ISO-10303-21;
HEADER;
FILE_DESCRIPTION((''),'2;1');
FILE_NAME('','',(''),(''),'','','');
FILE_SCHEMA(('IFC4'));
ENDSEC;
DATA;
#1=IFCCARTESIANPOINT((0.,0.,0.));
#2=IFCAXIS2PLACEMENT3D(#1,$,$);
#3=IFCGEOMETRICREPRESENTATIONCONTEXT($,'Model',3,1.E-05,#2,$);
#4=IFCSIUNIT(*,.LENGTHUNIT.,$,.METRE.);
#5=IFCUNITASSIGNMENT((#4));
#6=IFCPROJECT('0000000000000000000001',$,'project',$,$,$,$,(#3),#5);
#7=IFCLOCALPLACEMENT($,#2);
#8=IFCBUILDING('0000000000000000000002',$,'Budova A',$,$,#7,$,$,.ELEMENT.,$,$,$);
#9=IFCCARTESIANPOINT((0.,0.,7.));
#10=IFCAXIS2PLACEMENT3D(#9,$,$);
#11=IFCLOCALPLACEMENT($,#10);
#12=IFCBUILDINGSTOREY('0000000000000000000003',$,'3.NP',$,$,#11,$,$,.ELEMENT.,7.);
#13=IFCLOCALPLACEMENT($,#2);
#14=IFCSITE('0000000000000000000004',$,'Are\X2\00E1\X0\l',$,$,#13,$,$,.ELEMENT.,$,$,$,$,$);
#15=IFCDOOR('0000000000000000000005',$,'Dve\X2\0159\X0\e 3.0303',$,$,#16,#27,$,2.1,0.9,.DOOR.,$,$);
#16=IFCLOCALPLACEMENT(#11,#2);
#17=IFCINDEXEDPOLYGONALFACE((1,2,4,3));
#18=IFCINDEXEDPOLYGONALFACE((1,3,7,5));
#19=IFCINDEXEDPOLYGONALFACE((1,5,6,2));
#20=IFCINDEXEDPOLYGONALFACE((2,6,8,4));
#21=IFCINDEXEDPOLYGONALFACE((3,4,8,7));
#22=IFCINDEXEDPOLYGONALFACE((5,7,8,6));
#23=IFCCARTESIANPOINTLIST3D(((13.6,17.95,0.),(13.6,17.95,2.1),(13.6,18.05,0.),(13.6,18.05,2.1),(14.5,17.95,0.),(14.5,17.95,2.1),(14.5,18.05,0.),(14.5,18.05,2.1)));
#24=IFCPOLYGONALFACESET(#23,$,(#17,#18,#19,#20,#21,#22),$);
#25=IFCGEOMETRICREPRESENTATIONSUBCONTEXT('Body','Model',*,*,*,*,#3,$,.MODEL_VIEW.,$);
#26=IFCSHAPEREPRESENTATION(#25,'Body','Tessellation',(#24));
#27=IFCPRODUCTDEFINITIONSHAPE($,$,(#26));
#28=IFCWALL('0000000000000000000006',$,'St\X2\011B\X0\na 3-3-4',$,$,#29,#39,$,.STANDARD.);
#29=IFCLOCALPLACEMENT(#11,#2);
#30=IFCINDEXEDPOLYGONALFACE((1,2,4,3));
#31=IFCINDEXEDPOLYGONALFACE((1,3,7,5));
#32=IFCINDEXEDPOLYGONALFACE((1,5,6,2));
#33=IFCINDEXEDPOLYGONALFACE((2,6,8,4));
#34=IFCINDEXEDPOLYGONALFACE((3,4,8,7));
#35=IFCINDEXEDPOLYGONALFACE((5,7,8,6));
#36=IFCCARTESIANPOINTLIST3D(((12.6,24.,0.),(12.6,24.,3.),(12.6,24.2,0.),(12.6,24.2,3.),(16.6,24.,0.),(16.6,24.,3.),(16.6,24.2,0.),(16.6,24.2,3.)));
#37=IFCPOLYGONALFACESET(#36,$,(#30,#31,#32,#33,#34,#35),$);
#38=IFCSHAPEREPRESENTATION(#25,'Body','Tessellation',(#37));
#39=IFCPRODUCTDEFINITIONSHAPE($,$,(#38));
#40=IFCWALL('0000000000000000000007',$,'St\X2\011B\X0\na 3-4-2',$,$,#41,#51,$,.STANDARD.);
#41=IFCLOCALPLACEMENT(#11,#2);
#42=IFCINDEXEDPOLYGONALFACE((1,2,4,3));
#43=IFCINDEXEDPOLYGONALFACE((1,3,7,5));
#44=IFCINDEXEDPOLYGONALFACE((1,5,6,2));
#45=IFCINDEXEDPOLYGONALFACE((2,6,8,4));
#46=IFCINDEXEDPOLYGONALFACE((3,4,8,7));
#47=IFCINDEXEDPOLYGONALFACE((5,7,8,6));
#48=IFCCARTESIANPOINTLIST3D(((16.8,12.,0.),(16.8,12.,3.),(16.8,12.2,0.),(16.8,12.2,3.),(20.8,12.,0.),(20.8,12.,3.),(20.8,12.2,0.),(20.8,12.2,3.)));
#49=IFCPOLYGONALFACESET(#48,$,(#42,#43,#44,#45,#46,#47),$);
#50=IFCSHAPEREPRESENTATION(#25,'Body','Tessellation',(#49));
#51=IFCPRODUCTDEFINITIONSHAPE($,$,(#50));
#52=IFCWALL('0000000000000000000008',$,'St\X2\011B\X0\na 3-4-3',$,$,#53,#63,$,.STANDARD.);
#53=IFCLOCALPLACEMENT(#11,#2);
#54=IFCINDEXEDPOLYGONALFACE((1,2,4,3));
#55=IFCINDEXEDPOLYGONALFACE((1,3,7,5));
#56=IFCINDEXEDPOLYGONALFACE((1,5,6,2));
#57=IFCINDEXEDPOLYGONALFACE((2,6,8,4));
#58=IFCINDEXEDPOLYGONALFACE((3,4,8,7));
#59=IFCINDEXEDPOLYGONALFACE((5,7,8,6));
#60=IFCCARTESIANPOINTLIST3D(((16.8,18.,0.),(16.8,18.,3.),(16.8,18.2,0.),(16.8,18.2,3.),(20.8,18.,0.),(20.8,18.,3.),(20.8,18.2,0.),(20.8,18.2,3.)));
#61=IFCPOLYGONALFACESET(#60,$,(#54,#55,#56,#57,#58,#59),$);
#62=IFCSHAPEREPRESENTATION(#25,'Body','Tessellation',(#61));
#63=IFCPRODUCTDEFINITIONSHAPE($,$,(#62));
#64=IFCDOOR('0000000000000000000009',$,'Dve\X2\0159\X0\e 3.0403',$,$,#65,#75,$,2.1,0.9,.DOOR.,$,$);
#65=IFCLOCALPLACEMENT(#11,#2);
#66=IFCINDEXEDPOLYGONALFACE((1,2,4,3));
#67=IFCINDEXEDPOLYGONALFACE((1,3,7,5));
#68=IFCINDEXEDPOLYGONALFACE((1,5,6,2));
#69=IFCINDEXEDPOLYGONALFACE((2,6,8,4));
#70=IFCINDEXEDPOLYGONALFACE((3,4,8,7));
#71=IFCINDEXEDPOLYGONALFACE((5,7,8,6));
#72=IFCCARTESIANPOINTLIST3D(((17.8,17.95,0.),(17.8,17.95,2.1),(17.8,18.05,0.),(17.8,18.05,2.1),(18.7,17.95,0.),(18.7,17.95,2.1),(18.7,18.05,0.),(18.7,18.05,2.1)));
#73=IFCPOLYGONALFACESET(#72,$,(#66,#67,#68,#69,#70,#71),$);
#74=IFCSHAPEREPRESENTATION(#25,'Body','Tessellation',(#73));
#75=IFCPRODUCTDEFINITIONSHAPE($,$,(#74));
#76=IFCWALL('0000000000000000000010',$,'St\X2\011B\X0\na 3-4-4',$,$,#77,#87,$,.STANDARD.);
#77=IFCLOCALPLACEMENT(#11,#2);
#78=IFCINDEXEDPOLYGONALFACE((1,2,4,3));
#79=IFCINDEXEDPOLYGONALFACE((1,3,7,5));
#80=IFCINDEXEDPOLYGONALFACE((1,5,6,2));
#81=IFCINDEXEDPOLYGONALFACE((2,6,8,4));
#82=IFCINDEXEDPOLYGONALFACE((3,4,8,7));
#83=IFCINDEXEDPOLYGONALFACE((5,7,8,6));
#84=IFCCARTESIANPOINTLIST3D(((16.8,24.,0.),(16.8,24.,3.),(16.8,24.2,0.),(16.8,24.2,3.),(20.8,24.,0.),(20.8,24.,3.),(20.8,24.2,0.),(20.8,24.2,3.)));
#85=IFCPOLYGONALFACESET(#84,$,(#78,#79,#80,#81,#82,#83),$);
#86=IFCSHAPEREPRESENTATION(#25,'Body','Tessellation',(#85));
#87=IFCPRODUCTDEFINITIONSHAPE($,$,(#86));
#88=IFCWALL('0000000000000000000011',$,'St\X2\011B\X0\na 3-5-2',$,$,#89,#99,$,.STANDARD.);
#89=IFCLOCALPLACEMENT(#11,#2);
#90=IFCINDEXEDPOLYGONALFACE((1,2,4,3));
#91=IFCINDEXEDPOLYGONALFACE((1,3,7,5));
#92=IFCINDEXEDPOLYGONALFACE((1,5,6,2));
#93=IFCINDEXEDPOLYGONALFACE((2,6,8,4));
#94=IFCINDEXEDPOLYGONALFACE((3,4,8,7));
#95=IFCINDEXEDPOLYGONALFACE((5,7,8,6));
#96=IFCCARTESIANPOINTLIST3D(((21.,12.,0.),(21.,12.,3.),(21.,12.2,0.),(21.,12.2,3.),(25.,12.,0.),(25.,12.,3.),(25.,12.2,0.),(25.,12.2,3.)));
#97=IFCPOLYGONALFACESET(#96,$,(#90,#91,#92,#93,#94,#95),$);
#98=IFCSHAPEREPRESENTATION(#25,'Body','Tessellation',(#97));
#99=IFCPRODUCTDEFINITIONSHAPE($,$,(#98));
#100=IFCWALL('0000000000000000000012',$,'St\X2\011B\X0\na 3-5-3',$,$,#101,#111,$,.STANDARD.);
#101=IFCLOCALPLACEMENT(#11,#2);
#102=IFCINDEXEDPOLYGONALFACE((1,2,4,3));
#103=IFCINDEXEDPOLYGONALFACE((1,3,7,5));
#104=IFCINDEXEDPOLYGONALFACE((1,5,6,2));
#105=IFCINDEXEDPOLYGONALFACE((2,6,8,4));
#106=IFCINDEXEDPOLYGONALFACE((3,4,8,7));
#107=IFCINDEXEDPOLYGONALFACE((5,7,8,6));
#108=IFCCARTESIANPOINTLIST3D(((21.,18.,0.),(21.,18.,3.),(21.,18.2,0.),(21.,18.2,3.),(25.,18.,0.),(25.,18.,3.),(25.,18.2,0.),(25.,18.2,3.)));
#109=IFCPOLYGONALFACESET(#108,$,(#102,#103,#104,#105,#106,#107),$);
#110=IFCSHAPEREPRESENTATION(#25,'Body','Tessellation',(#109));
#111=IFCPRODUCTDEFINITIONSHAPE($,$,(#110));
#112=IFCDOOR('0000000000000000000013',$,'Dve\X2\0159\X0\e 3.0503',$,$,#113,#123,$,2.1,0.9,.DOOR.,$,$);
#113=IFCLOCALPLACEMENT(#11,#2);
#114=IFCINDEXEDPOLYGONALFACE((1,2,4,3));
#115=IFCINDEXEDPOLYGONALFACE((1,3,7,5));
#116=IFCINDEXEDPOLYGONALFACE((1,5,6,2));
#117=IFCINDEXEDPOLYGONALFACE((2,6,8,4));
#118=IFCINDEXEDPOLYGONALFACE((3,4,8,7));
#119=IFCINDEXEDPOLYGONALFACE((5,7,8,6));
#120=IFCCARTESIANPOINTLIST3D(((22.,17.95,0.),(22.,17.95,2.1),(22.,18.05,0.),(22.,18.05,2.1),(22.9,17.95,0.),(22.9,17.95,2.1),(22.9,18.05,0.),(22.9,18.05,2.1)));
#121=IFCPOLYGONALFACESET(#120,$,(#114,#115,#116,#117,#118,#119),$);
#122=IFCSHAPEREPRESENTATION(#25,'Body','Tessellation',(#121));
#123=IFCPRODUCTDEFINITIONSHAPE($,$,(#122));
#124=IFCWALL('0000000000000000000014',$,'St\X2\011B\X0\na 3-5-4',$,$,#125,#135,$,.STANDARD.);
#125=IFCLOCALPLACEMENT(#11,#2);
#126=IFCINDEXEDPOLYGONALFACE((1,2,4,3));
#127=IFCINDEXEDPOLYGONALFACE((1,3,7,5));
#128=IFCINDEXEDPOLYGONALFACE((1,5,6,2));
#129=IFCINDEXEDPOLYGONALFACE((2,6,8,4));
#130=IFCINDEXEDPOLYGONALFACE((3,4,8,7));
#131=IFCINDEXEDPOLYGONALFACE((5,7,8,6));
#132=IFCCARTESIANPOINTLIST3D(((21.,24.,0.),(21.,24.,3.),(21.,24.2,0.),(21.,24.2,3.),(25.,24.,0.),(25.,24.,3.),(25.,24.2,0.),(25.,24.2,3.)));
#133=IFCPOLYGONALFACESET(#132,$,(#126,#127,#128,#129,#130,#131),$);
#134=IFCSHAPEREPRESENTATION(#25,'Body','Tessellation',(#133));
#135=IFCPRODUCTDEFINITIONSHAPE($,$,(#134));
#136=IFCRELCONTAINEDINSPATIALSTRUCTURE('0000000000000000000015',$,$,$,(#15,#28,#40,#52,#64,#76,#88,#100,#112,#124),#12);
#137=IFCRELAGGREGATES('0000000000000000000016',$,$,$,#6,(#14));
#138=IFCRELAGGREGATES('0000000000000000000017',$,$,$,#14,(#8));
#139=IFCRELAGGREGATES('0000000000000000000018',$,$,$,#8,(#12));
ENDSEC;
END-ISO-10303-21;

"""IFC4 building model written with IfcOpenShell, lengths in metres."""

from ifc_helpers import new_model, si_unit, frame, frame_2d, origin, place, context, subcontext, project, spatial, rectangle, extrude, element, save


model = new_model("IFC4")

# Units and contexts
model_context = context("Model", 3, precision=1e-05, world=origin())
body_context = subcontext(model_context, "Body", "Model", "MODEL_VIEW")
ifc_project = project(units=[si_unit("LENGTHUNIT", "METRE")], contexts=[model_context])

# Site, building, storey
site_placement = place(None, origin())
site = spatial("IfcSite", under=ifc_project, at=site_placement, Name="Areál", CompositionType="ELEMENT")
building_placement = place(None, origin())
building = spatial("IfcBuilding", under=site, at=building_placement, Name="Budova A", CompositionType="ELEMENT")
storey_placement = place(None, frame((0.0, 0.0, 7.0)))
storey = spatial("IfcBuildingStorey", under=building, at=storey_placement, Name="3.NP", CompositionType="ELEMENT", Elevation=7.0)

# Door
door_1_placement = place(storey_placement, frame((13.6, 17.95, 0.0)))
element("IfcDoor", 1, at=door_1_placement, inside=storey, Name="Dveře 3.0303", OverallHeight=2.1, OverallWidth=0.9, PredefinedType="DOOR", context=body_context, shape_type="SweptSolid", body=[
    extrude(rectangle(XDim=0.9, YDim=0.1, at=frame_2d((0.45, 0.05))), origin(), (0.0, 0.0, 1.0), 2.1),
])

# Walls
for number, where, name in (
    (2, (12.6, 24.0, 0.0), "Stěna 3-3-4"),
    (3, (16.8, 12.0, 0.0), "Stěna 3-4-2"),
    (4, (16.8, 18.0, 0.0), "Stěna 3-4-3"),
):
    element("IfcWall", number, at=place(storey_placement, frame(where)), inside=storey, Name=name, PredefinedType="STANDARD", context=body_context, shape_type="SweptSolid", body=[
        extrude(rectangle(XDim=4.0, YDim=0.2, at=frame_2d((2.0, 0.1))), origin(), (0.0, 0.0, 1.0), 3.0),
    ])

# Door
door_2_placement = place(storey_placement, frame((17.8, 17.95, 0.0)))
element("IfcDoor", 5, at=door_2_placement, inside=storey, Name="Dveře 3.0403", OverallHeight=2.1, OverallWidth=0.9, PredefinedType="DOOR", context=body_context, shape_type="SweptSolid", body=[
    extrude(rectangle(XDim=0.9, YDim=0.1, at=frame_2d((0.45, 0.05))), origin(), (0.0, 0.0, 1.0), 2.1),
])

# Walls
for number, where, name in (
    (6, (16.8, 24.0, 0.0), "Stěna 3-4-4"),
    (7, (21.0, 12.0, 0.0), "Stěna 3-5-2"),
    (8, (21.0, 18.0, 0.0), "Stěna 3-5-3"),
):
    element("IfcWall", number, at=place(storey_placement, frame(where)), inside=storey, Name=name, PredefinedType="STANDARD", context=body_context, shape_type="SweptSolid", body=[
        extrude(rectangle(XDim=4.0, YDim=0.2, at=frame_2d((2.0, 0.1))), origin(), (0.0, 0.0, 1.0), 3.0),
    ])

# Door
door_3_placement = place(storey_placement, frame((22.0, 17.95, 0.0)))
element("IfcDoor", 9, at=door_3_placement, inside=storey, Name="Dveře 3.0503", OverallHeight=2.1, OverallWidth=0.9, PredefinedType="DOOR", context=body_context, shape_type="SweptSolid", body=[
    extrude(rectangle(XDim=0.9, YDim=0.1, at=frame_2d((0.45, 0.05))), origin(), (0.0, 0.0, 1.0), 2.1),
])

# Wall
wall_1_placement = place(storey_placement, frame((21.0, 24.0, 0.0)))
element("IfcWall", 10, at=wall_1_placement, inside=storey, Name="Stěna 3-5-4", PredefinedType="STANDARD", context=body_context, shape_type="SweptSolid", body=[
    extrude(rectangle(XDim=4.0, YDim=0.2, at=frame_2d((2.0, 0.1))), origin(), (0.0, 0.0, 1.0), 3.0),
])

save(model, "model.ifc")
